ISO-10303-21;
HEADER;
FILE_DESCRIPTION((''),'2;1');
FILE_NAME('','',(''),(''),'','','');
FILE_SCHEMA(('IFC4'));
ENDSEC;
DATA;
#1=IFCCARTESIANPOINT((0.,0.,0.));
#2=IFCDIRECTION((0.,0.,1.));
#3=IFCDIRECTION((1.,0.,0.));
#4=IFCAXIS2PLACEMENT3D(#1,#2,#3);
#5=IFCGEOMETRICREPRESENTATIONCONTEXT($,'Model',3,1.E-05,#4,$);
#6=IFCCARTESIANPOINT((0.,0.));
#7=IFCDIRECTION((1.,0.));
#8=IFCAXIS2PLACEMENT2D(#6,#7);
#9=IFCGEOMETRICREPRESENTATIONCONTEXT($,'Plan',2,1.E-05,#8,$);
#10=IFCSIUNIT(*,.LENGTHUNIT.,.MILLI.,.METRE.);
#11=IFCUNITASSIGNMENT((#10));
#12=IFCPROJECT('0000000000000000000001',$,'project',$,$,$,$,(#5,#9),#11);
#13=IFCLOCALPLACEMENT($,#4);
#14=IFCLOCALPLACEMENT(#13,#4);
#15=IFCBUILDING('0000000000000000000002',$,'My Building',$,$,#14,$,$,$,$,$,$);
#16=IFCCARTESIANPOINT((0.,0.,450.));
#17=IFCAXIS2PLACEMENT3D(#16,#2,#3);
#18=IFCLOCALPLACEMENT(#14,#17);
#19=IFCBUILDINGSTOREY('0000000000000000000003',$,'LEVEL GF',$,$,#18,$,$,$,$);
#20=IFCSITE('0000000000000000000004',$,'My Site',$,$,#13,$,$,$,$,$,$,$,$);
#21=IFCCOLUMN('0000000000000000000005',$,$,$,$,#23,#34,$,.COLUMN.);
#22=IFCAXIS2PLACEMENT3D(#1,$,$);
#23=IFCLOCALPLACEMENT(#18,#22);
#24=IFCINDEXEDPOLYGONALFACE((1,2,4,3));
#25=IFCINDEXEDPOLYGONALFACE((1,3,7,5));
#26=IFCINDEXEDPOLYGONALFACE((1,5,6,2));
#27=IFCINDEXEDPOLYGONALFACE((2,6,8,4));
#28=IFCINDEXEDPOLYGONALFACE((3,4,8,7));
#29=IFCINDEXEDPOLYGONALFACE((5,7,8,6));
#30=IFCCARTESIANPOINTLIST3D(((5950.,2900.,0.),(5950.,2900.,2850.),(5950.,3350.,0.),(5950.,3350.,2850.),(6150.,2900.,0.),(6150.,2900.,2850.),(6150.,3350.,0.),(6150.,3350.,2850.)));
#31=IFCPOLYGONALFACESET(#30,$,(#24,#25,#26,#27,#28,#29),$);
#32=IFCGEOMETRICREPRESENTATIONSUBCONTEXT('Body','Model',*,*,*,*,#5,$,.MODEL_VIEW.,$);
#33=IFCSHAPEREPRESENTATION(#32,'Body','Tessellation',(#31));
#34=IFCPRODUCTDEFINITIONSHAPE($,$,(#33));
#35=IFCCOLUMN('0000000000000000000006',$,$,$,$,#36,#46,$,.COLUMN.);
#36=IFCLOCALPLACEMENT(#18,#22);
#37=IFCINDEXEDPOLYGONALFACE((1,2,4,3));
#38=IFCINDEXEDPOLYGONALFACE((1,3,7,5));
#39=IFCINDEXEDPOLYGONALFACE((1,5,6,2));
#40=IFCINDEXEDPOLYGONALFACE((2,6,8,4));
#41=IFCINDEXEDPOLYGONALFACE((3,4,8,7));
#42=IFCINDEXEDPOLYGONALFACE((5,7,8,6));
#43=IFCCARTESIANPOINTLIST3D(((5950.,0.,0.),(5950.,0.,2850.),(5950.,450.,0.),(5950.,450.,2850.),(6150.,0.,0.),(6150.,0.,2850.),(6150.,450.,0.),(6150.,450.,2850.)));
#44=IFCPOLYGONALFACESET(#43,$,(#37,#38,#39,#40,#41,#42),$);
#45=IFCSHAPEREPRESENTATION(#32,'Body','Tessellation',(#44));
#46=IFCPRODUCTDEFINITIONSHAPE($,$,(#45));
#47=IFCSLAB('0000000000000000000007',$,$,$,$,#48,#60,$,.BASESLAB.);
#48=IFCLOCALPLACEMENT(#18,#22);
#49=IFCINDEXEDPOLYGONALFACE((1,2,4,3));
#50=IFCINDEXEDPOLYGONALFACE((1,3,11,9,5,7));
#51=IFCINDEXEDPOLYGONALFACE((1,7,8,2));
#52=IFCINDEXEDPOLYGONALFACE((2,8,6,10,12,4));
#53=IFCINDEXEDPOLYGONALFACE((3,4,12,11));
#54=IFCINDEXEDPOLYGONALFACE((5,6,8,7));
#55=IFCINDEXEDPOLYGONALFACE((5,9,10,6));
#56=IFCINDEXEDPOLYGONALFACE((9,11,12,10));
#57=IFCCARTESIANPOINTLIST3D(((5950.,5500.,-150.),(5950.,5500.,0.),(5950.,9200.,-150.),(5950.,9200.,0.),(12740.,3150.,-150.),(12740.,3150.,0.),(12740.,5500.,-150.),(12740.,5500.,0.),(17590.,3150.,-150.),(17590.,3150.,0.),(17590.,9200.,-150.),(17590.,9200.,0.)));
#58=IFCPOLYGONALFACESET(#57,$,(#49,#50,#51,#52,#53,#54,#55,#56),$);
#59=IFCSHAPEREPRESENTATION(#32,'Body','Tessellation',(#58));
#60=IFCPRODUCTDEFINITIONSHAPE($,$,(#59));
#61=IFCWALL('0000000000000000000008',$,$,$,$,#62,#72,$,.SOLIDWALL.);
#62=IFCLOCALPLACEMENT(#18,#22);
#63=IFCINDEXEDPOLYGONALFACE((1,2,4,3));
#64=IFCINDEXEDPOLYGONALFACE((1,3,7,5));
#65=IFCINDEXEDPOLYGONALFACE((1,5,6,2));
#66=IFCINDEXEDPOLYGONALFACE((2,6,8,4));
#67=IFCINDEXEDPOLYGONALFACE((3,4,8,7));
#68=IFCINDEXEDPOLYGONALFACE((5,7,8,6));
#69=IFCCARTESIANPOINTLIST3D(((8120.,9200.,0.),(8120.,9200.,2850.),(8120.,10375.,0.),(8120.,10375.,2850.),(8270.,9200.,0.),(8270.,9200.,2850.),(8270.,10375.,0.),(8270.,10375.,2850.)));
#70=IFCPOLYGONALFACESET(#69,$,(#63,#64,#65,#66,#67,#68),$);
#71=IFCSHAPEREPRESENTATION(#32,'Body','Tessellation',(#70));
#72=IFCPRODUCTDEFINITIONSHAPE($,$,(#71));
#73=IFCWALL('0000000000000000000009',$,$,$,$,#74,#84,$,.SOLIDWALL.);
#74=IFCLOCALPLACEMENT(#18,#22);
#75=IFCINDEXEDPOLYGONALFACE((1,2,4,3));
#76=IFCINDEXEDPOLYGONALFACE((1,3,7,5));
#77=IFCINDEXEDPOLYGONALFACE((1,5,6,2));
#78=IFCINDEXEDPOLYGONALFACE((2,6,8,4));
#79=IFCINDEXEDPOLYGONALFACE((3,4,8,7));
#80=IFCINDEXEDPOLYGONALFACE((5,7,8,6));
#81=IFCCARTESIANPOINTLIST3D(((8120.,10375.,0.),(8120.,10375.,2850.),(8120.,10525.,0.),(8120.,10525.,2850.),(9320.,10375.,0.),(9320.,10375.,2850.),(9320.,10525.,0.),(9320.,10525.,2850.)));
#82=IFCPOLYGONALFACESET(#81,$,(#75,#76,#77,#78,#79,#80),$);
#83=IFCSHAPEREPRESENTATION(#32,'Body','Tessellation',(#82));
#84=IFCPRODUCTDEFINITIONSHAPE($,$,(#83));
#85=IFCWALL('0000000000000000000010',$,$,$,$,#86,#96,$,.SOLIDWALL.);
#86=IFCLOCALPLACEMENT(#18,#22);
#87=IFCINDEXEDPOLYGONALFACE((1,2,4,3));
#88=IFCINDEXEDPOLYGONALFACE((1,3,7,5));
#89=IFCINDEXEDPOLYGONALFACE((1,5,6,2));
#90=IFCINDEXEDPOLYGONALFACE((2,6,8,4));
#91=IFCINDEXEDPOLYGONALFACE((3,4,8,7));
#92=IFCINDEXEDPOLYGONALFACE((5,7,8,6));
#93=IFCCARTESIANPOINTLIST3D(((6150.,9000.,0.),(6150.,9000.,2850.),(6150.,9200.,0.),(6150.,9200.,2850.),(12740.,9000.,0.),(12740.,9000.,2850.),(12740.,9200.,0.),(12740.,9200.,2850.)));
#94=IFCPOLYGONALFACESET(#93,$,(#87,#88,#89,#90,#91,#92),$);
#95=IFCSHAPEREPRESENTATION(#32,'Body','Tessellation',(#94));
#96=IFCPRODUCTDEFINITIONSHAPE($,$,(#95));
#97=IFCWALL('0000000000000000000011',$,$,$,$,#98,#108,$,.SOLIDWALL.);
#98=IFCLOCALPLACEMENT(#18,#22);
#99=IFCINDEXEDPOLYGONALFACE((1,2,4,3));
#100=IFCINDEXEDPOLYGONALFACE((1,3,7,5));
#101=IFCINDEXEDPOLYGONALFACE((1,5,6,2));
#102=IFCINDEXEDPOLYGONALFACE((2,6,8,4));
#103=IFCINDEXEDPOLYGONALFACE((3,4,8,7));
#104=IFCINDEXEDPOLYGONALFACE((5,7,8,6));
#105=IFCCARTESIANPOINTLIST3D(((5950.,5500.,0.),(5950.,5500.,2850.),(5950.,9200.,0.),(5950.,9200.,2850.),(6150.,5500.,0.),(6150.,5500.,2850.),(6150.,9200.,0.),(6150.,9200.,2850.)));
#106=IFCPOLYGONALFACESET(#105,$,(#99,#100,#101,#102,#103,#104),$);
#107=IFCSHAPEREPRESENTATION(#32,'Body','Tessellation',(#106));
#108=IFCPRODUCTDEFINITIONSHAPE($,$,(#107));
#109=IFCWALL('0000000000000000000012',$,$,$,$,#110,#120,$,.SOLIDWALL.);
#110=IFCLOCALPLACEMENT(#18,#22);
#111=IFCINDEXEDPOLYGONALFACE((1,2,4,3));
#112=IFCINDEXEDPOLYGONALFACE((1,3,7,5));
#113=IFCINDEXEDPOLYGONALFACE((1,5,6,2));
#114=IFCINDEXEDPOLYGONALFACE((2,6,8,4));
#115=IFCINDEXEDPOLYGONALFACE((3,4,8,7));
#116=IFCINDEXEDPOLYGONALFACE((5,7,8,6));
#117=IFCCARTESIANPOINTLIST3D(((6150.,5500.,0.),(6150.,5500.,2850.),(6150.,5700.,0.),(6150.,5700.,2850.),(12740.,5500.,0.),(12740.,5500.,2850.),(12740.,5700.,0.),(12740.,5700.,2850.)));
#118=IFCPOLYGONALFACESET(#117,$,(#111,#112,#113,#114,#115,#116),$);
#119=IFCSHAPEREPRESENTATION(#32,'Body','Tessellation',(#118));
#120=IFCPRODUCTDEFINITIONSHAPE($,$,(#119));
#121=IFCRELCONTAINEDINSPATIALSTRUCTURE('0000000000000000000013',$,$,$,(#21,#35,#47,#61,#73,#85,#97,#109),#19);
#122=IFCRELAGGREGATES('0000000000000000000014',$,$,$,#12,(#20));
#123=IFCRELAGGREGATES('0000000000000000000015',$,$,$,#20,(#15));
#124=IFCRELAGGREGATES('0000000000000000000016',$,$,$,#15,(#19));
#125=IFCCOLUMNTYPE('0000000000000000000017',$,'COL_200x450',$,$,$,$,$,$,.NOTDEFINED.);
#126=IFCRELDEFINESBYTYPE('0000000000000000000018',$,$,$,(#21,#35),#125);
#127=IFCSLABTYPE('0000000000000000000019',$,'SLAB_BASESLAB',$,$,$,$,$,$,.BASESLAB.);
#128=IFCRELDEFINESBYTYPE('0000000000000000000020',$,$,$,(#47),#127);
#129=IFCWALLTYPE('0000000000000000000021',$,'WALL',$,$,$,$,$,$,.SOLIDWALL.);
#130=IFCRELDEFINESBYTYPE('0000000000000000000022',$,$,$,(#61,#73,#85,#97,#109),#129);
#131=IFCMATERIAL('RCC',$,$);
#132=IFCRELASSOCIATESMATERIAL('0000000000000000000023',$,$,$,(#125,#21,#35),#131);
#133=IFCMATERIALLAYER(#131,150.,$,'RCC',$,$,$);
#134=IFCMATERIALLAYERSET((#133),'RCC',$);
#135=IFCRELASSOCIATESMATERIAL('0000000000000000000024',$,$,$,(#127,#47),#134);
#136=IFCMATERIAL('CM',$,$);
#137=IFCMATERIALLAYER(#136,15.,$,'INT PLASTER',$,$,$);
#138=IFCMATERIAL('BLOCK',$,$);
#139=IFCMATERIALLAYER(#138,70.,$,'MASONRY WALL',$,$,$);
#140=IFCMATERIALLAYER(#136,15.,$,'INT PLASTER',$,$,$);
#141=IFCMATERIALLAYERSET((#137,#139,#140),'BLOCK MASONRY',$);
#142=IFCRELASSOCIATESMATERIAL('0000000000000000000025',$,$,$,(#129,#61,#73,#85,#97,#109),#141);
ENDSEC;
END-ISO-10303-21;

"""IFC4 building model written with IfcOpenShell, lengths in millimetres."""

from ifc_helpers import new_model, si_unit, frame, origin_with_axes, origin_2d_with_axis, place, context, subcontext, project, spatial, indexed_curve, rectangle, outline, extrude, material, layer, layer_set, layer_usage, material_profile, profile_set, profile_usage, type_object, element, save


model = new_model("IFC4")

# Units and contexts
model_context = context("Model", 3, precision=1e-05, world=origin_with_axes())
plan_context = context("Plan", 2, precision=1e-05, world=origin_2d_with_axis())
body_context = subcontext(model_context, "Body", "Model", "MODEL_VIEW")
ifc_project = project(units=[si_unit("LENGTHUNIT", "METRE", prefix="MILLI")], contexts=[model_context, plan_context])

# Site, building, storey
site_placement = place(None, origin_with_axes())
site = spatial("IfcSite", under=ifc_project, at=site_placement, Name="My Site")
building_placement = place(site_placement, origin_with_axes())
building = spatial("IfcBuilding", under=site, at=building_placement, Name="My Building")
storey_placement = place(building_placement, frame((0.0, 0.0, 450.0), z_axis=(0.0, 0.0, 1.0), x_axis=(1.0, 0.0, 0.0)))
storey = spatial("IfcBuildingStorey", under=building, at=storey_placement, Name="LEVEL GF")

# Columns
ifc_material_1 = material(Name="RCC")
ifc_material_profile = material_profile(ifc_material_1, rectangle(XDim=200.0, YDim=450.0))
ifc_profile_set = profile_set([ifc_material_profile], Name="COL_200x450")
column_type = type_object("IfcColumnType", Name="COL_200x450", PredefinedType="NOTDEFINED", material=ifc_profile_set)
ifc_profile_usage_1 = profile_usage(ifc_profile_set)
column_1_placement = place(storey_placement, frame((6050.0, 3125.0, 0.0), z_axis=(0.0, 0.0, 1.0), x_axis=(1.0, 0.0, 0.0)))
element("IfcColumn", 1, at=column_1_placement, inside=storey, type_object=column_type, material=ifc_profile_usage_1, PredefinedType="COLUMN", context=body_context, shape_type="SweptSolid", body=[
    extrude(rectangle(XDim=200.0, YDim=450.0), origin_with_axes(), (0.0, 0.0, 1.0), 2850.0),
])
ifc_profile_usage_2 = profile_usage(ifc_profile_set)
column_2_placement = place(storey_placement, frame((6050.0, 225.0, 0.0), z_axis=(0.0, 0.0, 1.0), x_axis=(1.0, 0.0, 0.0)))
element("IfcColumn", 2, at=column_2_placement, inside=storey, type_object=column_type, material=ifc_profile_usage_2, PredefinedType="COLUMN", context=body_context, shape_type="SweptSolid", body=[
    extrude(rectangle(XDim=200.0, YDim=450.0), origin_with_axes(), (0.0, 0.0, 1.0), 2850.0),
])

# Slab
ifc_layer_1 = layer(ifc_material_1, 150.0, Name="RCC")
ifc_layer_set_1 = layer_set([ifc_layer_1], Name="RCC")
ifc_layer_usage_1 = layer_usage(ifc_layer_set_1, "AXIS3", "POSITIVE", 0.0)
slab_type = type_object("IfcSlabType", Name="SLAB_BASESLAB", PredefinedType="BASESLAB", material=ifc_layer_set_1)
slab_placement = place(storey_placement, frame((0.0, 0.0, -150.0), z_axis=(0.0, 0.0, 1.0), x_axis=(1.0, 0.0, 0.0)))
element("IfcSlab", 3, at=slab_placement, inside=storey, type_object=slab_type, material=ifc_layer_usage_1, PredefinedType="BASESLAB", context=body_context, shape_type="SweptSolid", body=[
    extrude(outline(indexed_curve([(5950.0, 9200.0), (17590.0, 9200.0), (17590.0, 3150.0), (12740.0, 3150.0), (12740.0, 5500.0), (5950.0, 5500.0)])), None, (0.0, 0.0, 1.0), 150.0),
])

# Walls
ifc_material_2 = material(Name="CM")
ifc_layer_2 = layer(ifc_material_2, 15.0, Name="INT PLASTER")
ifc_material_3 = material(Name="BLOCK")
ifc_layer_3 = layer(ifc_material_3, 70.0, Name="MASONRY WALL")
ifc_layer_4 = layer(ifc_material_2, 15.0, Name="INT PLASTER")
ifc_layer_set_2 = layer_set([ifc_layer_2, ifc_layer_3, ifc_layer_4], Name="BLOCK MASONRY")
ifc_layer_usage_2 = layer_usage(ifc_layer_set_2, "AXIS2", "POSITIVE", 0.0)
wall_type = type_object("IfcWallType", Name="WALL", PredefinedType="SOLIDWALL", material=ifc_layer_set_2)
wall_1_placement = place(storey_placement, frame((8270.0, 9200.0, 0.0), z_axis=(0.0, 0.0, 1.0), x_axis=(0.0, 1.0, 0.0)))
element("IfcWall", 4, at=wall_1_placement, inside=storey, type_object=wall_type, material=ifc_layer_usage_2, PredefinedType="SOLIDWALL", context=body_context, shape_type="SweptSolid", body=[
    extrude(outline(indexed_curve([(0.0, 0.0), (0.0, 150.0), (1175.0, 150.0), (1175.0, 0.0), (0.0, 0.0)], self_intersect=False)), origin_with_axes(), (0.0, 0.0, 1.0), 2850.0),
])
ifc_layer_usage_3 = layer_usage(ifc_layer_set_2, "AXIS2", "POSITIVE", 0.0)
wall_2_placement = place(storey_placement, frame((8120.0, 10525.0, 0.0), z_axis=(0.0, 0.0, 1.0), x_axis=(0.0, -1.0, 0.0)))
element("IfcWall", 5, at=wall_2_placement, inside=storey, type_object=wall_type, material=ifc_layer_usage_3, PredefinedType="SOLIDWALL", context=body_context, shape_type="SweptSolid", body=[
    extrude(outline(indexed_curve([(0.0, 0.0), (0.0, 1200.0), (150.0, 1200.0), (150.0, 0.0), (0.0, 0.0)], self_intersect=False)), origin_with_axes(), (0.0, 0.0, 1.0), 2850.0),
])
ifc_layer_usage_4 = layer_usage(ifc_layer_set_2, "AXIS2", "POSITIVE", 0.0)
wall_3_placement = place(storey_placement, frame((6150.0, 9200.0, 0.0), z_axis=(0.0, 0.0, 1.0), x_axis=(0.0, -1.0, 0.0)))
element("IfcWall", 6, at=wall_3_placement, inside=storey, type_object=wall_type, material=ifc_layer_usage_4, PredefinedType="SOLIDWALL", context=body_context, shape_type="SweptSolid", body=[
    extrude(outline(indexed_curve([(0.0, 0.0), (0.0, 6590.0), (200.0, 6590.0), (200.0, 0.0), (0.0, 0.0)], self_intersect=False)), origin_with_axes(), (0.0, 0.0, 1.0), 2850.0),
])
ifc_layer_usage_5 = layer_usage(ifc_layer_set_2, "AXIS2", "POSITIVE", 0.0)
wall_4_placement = place(storey_placement, frame((6150.0, 5500.0, 0.0), z_axis=(0.0, 0.0, 1.0), x_axis=(0.0, 1.0, 0.0)))
element("IfcWall", 7, at=wall_4_placement, inside=storey, type_object=wall_type, material=ifc_layer_usage_5, PredefinedType="SOLIDWALL", context=body_context, shape_type="SweptSolid", body=[
    extrude(outline(indexed_curve([(0.0, 0.0), (0.0, 200.0), (3700.0, 200.0), (3700.0, 0.0), (0.0, 0.0)], self_intersect=False)), origin_with_axes(), (0.0, 0.0, 1.0), 2850.0),
])
ifc_layer_usage_6 = layer_usage(ifc_layer_set_2, "AXIS2", "POSITIVE", 0.0)
wall_5_placement = place(storey_placement, frame((6150.0, 5700.0, 0.0), z_axis=(0.0, 0.0, 1.0), x_axis=(0.0, -1.0, 0.0)))
element("IfcWall", 8, at=wall_5_placement, inside=storey, type_object=wall_type, material=ifc_layer_usage_6, PredefinedType="SOLIDWALL", context=body_context, shape_type="SweptSolid", body=[
    extrude(outline(indexed_curve([(0.0, 0.0), (0.0, 6590.0), (200.0, 6590.0), (200.0, 0.0), (0.0, 0.0)], self_intersect=False)), origin_with_axes(), (0.0, 0.0, 1.0), 2850.0),
])

save(model, "model.ifc")
